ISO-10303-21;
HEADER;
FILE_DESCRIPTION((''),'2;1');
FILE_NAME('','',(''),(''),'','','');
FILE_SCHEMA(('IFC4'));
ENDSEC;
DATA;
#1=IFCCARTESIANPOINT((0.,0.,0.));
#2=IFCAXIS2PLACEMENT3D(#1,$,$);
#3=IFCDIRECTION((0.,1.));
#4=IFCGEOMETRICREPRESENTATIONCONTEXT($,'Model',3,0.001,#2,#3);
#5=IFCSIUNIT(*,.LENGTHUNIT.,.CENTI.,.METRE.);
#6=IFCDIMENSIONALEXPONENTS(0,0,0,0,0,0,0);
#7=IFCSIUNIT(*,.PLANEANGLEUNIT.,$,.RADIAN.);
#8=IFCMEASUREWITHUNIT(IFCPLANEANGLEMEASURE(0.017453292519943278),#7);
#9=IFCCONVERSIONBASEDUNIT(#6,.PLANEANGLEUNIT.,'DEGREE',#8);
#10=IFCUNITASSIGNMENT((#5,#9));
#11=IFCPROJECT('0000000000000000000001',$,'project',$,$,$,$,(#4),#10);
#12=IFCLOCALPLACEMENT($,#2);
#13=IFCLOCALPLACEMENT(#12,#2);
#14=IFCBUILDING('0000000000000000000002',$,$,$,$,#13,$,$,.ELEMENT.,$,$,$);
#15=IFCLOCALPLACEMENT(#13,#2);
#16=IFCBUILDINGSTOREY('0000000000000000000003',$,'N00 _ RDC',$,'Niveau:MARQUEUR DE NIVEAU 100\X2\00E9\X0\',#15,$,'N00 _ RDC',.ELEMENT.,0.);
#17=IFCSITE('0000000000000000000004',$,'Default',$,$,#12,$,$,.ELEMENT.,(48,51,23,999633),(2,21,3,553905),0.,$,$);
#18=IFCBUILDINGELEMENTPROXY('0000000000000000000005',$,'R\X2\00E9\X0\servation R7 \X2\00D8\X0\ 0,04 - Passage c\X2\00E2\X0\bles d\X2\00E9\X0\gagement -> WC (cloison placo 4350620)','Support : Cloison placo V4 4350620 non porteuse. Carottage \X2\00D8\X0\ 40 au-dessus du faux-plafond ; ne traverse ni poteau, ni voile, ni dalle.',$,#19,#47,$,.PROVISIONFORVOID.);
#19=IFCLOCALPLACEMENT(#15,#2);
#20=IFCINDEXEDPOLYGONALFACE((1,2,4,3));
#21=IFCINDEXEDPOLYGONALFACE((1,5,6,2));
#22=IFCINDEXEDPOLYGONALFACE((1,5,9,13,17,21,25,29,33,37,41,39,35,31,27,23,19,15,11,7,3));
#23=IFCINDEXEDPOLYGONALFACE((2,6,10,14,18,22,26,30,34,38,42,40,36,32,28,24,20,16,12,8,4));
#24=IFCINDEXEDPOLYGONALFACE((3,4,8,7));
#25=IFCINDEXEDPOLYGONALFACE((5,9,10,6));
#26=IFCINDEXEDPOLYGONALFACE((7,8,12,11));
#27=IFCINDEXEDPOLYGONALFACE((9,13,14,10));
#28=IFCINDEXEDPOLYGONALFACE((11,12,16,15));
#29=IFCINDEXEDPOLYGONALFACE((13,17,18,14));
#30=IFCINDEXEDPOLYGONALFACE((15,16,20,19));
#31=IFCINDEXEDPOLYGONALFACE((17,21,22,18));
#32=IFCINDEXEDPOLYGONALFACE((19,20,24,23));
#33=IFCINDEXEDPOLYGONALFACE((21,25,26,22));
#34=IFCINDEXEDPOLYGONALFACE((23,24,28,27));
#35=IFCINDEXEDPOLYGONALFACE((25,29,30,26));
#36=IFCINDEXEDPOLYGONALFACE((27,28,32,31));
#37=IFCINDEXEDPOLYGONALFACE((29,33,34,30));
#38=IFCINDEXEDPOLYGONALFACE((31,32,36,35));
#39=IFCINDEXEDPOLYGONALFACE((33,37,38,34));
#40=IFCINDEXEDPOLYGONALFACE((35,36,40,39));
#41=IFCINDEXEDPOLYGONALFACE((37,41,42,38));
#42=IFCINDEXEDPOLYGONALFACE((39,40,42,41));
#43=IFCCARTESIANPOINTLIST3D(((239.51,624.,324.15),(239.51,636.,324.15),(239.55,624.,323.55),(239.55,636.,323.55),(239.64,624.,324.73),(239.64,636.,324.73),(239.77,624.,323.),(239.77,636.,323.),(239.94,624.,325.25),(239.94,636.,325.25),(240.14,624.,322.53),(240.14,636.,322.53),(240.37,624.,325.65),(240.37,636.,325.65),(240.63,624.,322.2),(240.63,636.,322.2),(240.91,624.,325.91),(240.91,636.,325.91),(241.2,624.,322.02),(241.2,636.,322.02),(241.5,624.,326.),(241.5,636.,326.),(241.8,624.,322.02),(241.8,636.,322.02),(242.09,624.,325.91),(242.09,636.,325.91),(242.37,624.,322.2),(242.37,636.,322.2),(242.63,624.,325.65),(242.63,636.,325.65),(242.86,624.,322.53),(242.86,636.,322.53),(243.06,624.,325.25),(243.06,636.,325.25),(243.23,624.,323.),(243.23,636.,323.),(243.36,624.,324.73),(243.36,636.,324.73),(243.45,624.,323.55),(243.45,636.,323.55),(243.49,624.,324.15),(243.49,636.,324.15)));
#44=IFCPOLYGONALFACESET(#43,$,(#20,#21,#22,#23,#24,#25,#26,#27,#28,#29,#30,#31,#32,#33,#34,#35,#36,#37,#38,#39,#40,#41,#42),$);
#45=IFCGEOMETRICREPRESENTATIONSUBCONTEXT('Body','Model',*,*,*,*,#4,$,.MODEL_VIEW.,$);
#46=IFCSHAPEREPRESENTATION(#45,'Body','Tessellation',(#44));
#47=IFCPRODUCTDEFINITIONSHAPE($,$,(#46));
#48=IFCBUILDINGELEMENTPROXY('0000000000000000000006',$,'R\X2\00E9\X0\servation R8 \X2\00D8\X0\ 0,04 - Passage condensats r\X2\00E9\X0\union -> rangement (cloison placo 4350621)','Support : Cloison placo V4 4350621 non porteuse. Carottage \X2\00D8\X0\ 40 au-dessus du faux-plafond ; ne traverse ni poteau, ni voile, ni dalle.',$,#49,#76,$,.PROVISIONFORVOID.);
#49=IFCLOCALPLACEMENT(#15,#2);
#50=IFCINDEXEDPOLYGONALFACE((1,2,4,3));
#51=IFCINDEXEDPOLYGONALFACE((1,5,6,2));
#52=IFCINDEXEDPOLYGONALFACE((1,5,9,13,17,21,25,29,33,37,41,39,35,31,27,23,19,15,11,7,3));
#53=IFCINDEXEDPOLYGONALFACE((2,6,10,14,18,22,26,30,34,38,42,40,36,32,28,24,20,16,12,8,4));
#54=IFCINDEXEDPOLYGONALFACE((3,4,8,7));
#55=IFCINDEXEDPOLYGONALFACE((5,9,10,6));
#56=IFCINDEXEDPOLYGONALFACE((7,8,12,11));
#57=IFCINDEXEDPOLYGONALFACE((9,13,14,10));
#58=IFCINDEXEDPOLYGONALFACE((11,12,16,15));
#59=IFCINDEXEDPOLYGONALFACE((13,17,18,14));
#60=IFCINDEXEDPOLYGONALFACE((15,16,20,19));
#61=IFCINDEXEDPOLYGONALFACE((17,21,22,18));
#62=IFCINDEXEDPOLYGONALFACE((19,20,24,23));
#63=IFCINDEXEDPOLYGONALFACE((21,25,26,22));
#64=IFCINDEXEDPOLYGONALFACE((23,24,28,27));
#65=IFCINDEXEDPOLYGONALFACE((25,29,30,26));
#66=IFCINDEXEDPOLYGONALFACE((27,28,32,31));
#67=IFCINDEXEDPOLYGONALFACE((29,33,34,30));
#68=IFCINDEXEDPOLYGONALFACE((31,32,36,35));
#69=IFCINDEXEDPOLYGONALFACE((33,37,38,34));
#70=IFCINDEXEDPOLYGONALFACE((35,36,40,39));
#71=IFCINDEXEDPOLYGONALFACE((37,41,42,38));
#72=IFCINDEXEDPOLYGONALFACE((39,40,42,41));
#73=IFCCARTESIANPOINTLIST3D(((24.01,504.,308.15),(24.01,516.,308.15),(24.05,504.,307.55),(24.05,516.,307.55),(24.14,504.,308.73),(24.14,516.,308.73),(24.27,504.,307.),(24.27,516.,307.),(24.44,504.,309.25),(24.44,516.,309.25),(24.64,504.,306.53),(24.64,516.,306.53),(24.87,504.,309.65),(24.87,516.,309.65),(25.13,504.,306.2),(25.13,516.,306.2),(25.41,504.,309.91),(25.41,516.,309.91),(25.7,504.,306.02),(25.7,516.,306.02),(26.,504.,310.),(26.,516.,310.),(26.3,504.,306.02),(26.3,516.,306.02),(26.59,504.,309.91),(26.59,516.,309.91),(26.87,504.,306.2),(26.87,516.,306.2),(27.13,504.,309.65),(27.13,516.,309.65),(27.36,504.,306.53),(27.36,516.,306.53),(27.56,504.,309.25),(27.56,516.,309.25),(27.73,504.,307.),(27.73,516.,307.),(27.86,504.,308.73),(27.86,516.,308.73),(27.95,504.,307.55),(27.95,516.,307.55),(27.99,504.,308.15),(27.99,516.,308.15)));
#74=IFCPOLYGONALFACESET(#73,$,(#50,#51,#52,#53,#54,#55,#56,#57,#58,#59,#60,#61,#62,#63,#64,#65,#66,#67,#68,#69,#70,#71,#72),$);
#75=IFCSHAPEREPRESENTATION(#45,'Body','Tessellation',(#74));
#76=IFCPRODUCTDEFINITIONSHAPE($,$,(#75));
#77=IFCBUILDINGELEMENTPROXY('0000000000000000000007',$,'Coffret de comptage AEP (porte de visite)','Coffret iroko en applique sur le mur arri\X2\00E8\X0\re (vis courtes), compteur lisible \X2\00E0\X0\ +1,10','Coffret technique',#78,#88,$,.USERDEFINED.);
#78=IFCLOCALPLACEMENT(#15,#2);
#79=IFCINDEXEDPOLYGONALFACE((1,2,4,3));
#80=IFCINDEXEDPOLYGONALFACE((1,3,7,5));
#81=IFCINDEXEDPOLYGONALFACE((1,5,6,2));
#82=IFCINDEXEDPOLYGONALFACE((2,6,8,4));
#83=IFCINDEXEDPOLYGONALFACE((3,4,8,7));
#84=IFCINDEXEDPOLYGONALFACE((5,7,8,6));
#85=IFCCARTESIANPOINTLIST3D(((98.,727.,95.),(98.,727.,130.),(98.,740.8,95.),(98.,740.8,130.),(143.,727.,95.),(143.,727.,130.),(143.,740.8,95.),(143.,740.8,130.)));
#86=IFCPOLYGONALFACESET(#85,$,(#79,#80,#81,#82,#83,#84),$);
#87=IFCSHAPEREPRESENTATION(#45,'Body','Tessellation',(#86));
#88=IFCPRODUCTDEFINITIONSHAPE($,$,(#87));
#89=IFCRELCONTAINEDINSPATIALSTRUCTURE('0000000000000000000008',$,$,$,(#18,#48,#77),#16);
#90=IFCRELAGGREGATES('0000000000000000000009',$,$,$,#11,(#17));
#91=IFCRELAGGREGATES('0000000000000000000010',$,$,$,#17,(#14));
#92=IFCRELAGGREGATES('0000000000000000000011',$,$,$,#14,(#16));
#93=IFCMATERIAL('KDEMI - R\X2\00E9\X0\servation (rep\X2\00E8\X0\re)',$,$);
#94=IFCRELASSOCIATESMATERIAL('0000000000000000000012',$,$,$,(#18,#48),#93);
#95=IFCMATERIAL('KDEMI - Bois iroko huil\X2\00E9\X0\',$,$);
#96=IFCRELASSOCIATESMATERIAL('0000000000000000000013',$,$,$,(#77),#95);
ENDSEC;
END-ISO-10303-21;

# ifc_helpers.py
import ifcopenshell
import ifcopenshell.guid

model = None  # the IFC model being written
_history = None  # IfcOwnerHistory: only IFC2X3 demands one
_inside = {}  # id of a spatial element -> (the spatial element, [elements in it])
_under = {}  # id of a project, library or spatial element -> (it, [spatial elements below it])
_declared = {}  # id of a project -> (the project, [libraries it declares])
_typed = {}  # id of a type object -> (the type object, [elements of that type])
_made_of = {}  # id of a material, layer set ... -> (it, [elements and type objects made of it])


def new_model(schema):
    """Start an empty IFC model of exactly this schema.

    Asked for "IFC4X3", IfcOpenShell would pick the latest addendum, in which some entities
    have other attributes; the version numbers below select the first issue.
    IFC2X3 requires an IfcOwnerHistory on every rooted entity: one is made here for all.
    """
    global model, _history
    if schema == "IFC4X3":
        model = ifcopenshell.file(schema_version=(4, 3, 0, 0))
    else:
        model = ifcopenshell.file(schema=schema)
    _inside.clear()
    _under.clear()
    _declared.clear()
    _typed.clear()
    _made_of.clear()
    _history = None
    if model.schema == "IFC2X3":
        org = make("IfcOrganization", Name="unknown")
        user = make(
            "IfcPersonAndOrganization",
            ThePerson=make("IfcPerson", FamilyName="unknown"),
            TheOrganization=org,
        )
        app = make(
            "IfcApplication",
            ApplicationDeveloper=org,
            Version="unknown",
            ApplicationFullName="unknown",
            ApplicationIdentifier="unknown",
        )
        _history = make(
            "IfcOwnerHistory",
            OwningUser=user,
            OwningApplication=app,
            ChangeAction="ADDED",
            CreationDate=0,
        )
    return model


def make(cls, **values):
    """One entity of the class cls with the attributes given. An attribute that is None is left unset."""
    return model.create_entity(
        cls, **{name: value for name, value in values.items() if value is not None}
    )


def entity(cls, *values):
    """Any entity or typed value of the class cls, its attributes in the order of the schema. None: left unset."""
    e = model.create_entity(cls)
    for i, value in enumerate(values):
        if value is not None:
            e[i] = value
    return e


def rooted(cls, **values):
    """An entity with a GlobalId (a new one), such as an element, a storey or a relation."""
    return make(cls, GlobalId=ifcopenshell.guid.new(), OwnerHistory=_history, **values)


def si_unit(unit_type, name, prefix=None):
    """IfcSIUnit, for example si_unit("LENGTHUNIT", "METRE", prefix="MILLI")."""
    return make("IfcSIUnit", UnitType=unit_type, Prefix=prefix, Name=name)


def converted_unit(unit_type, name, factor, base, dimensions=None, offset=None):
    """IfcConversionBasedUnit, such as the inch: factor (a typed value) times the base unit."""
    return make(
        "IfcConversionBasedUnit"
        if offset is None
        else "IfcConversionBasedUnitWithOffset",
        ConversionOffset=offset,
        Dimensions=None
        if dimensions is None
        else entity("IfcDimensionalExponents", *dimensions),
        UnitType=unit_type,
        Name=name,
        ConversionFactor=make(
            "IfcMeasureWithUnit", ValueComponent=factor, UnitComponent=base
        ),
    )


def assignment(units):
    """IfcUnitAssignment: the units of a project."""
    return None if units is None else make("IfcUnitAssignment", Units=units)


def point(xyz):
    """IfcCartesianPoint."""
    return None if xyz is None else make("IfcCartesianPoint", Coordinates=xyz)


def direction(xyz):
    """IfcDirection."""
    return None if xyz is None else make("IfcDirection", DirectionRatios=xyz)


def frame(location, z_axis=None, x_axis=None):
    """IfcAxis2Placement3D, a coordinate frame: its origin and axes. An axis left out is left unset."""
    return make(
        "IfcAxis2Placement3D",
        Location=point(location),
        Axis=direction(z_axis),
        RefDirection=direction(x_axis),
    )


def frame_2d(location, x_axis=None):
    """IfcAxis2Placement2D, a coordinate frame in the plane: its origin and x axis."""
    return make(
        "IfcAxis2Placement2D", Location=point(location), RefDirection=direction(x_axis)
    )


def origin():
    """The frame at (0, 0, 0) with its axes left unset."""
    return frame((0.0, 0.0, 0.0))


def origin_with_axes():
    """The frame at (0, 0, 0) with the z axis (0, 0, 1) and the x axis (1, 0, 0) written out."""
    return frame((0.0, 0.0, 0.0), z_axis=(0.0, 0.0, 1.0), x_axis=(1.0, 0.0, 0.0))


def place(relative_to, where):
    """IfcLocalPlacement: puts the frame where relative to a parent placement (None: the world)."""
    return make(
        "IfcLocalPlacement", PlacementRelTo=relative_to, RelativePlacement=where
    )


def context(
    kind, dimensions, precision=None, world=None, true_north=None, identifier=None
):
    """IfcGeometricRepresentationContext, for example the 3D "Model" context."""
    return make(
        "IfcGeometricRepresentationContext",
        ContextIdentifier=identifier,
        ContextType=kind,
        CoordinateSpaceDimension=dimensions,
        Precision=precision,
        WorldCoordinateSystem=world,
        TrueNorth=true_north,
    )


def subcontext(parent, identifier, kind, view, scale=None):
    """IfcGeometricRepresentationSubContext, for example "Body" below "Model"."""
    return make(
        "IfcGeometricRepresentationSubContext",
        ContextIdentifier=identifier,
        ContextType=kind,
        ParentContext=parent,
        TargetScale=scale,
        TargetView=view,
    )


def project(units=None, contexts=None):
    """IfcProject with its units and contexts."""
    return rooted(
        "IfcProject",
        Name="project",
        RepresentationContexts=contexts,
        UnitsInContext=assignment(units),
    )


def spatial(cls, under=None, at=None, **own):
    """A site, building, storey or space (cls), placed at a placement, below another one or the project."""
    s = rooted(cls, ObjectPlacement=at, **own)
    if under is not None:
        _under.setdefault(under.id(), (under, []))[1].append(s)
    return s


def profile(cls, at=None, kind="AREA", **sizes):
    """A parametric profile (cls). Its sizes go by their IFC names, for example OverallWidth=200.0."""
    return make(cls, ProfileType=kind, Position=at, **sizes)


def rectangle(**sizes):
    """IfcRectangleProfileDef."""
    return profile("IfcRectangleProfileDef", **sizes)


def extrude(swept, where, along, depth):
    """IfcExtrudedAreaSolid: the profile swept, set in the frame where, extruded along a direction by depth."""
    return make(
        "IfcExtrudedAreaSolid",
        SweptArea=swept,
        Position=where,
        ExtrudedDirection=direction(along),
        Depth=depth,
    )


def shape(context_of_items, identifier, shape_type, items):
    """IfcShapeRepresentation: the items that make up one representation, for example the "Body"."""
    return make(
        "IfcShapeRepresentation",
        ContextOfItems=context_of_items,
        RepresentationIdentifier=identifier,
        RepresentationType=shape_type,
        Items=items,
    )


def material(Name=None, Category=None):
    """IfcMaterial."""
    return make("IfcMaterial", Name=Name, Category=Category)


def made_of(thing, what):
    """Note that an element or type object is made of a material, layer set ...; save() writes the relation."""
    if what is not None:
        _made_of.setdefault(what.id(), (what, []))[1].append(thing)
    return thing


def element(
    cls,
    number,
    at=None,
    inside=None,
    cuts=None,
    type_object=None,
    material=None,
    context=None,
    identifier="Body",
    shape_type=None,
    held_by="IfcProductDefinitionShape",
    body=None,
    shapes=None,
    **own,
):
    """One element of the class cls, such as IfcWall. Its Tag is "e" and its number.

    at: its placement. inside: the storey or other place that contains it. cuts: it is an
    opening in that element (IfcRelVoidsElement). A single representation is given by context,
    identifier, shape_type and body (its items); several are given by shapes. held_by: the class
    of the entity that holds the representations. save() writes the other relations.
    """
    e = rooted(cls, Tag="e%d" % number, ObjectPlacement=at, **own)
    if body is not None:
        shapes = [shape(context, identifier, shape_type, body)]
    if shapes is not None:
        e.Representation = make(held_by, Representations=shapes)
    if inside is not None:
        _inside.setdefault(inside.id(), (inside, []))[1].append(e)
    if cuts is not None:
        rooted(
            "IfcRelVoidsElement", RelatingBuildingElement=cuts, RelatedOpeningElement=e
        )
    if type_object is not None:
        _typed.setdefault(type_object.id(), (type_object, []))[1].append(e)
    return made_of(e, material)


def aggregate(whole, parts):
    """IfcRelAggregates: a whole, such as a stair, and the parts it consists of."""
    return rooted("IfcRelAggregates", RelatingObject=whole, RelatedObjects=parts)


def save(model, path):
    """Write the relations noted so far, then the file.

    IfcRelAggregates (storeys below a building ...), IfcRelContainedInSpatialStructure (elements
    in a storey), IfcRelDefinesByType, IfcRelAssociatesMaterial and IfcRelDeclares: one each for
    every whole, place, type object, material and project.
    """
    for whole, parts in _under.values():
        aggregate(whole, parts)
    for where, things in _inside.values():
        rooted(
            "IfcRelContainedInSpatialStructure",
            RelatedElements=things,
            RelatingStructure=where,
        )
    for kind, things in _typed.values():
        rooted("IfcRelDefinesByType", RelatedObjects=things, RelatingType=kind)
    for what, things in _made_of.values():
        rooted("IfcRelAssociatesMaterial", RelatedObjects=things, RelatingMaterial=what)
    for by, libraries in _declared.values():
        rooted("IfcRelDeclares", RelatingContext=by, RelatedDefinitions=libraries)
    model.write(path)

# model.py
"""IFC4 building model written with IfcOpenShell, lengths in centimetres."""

from ifc_helpers import new_model, entity, si_unit, converted_unit, direction, frame, frame_2d, origin, origin_with_axes, place, context, subcontext, project, spatial, rectangle, extrude, material, element, save


model = new_model("IFC4")

# Units and contexts
model_context = context("Model", 3, precision=0.001, world=origin(), true_north=direction((0.0, 1.0)))
body_context = subcontext(model_context, "Body", "Model", "MODEL_VIEW")
ifc_project = project(units=[si_unit("LENGTHUNIT", "METRE", prefix="CENTI"), converted_unit("PLANEANGLEUNIT", "DEGREE", entity("IfcPlaneAngleMeasure", 0.017453292519943278), si_unit("PLANEANGLEUNIT", "RADIAN"), dimensions=[0, 0, 0, 0, 0, 0, 0])], contexts=[model_context])

# Site, building, storey
site_placement = place(None, origin())
site = spatial("IfcSite", under=ifc_project, at=site_placement, Name="Default", CompositionType="ELEMENT", RefLatitude=(48, 51, 23, 999633), RefLongitude=(2, 21, 3, 553905), RefElevation=0.0)
building_placement = place(site_placement, origin())
building = spatial("IfcBuilding", under=site, at=building_placement, CompositionType="ELEMENT")
storey_placement = place(building_placement, origin())
storey = spatial("IfcBuildingStorey", under=building, at=storey_placement, Name="N00 _ RDC", ObjectType="Niveau:MARQUEUR DE NIVEAU 100é", LongName="N00 _ RDC", CompositionType="ELEMENT", Elevation=0.0)

# Building element proxies
ifc_material_1 = material(Name="KDEMI - Réservation (repère)")
proxy_1_placement = place(storey_placement, origin_with_axes())
element("IfcBuildingElementProxy", 1, at=proxy_1_placement, inside=storey, material=ifc_material_1, Name="Réservation R7 Ø 0,04 - Passage câbles dégagement -> WC (cloison placo 4350620)", Description="Support : Cloison placo V4 4350620 non porteuse. Carottage Ø 40 au-dessus du faux-plafond ; ne traverse ni poteau, ni voile, ni dalle.", PredefinedType="PROVISIONFORVOID", context=body_context, shape_type="AdvancedSweptSolid", body=[
    entity("IfcSweptDiskSolid", entity("IfcPolyline", [entity("IfcCartesianPoint", [241.5, 624.0, 324.0]), entity("IfcCartesianPoint", [241.5, 636.0, 324.0])]), 2.0),
])
proxy_2_placement = place(storey_placement, origin_with_axes())
element("IfcBuildingElementProxy", 2, at=proxy_2_placement, inside=storey, material=ifc_material_1, Name="Réservation R8 Ø 0,04 - Passage condensats réunion -> rangement (cloison placo 4350621)", Description="Support : Cloison placo V4 4350621 non porteuse. Carottage Ø 40 au-dessus du faux-plafond ; ne traverse ni poteau, ni voile, ni dalle.", PredefinedType="PROVISIONFORVOID", context=body_context, shape_type="AdvancedSweptSolid", body=[
    entity("IfcSweptDiskSolid", entity("IfcPolyline", [entity("IfcCartesianPoint", [26.0, 504.0, 308.0]), entity("IfcCartesianPoint", [26.0, 516.0, 308.0])]), 2.0),
])
ifc_material_2 = material(Name="KDEMI - Bois iroko huilé")
proxy_3_placement = place(storey_placement, origin_with_axes())
element("IfcBuildingElementProxy", 3, at=proxy_3_placement, inside=storey, material=ifc_material_2, Name="Coffret de comptage AEP (porte de visite)", Description="Coffret iroko en applique sur le mur arrière (vis courtes), compteur lisible à +1,10", ObjectType="Coffret technique", PredefinedType="USERDEFINED", context=body_context, shape_type="SweptSolid", body=[
    extrude(rectangle(XDim=45.0, YDim=13.8, at=frame_2d((120.5, 733.9))), frame((0.0, 0.0, 95.0)), (0.0, 0.0, 1.0), 35.0),
])

save(model, "model.ifc")
